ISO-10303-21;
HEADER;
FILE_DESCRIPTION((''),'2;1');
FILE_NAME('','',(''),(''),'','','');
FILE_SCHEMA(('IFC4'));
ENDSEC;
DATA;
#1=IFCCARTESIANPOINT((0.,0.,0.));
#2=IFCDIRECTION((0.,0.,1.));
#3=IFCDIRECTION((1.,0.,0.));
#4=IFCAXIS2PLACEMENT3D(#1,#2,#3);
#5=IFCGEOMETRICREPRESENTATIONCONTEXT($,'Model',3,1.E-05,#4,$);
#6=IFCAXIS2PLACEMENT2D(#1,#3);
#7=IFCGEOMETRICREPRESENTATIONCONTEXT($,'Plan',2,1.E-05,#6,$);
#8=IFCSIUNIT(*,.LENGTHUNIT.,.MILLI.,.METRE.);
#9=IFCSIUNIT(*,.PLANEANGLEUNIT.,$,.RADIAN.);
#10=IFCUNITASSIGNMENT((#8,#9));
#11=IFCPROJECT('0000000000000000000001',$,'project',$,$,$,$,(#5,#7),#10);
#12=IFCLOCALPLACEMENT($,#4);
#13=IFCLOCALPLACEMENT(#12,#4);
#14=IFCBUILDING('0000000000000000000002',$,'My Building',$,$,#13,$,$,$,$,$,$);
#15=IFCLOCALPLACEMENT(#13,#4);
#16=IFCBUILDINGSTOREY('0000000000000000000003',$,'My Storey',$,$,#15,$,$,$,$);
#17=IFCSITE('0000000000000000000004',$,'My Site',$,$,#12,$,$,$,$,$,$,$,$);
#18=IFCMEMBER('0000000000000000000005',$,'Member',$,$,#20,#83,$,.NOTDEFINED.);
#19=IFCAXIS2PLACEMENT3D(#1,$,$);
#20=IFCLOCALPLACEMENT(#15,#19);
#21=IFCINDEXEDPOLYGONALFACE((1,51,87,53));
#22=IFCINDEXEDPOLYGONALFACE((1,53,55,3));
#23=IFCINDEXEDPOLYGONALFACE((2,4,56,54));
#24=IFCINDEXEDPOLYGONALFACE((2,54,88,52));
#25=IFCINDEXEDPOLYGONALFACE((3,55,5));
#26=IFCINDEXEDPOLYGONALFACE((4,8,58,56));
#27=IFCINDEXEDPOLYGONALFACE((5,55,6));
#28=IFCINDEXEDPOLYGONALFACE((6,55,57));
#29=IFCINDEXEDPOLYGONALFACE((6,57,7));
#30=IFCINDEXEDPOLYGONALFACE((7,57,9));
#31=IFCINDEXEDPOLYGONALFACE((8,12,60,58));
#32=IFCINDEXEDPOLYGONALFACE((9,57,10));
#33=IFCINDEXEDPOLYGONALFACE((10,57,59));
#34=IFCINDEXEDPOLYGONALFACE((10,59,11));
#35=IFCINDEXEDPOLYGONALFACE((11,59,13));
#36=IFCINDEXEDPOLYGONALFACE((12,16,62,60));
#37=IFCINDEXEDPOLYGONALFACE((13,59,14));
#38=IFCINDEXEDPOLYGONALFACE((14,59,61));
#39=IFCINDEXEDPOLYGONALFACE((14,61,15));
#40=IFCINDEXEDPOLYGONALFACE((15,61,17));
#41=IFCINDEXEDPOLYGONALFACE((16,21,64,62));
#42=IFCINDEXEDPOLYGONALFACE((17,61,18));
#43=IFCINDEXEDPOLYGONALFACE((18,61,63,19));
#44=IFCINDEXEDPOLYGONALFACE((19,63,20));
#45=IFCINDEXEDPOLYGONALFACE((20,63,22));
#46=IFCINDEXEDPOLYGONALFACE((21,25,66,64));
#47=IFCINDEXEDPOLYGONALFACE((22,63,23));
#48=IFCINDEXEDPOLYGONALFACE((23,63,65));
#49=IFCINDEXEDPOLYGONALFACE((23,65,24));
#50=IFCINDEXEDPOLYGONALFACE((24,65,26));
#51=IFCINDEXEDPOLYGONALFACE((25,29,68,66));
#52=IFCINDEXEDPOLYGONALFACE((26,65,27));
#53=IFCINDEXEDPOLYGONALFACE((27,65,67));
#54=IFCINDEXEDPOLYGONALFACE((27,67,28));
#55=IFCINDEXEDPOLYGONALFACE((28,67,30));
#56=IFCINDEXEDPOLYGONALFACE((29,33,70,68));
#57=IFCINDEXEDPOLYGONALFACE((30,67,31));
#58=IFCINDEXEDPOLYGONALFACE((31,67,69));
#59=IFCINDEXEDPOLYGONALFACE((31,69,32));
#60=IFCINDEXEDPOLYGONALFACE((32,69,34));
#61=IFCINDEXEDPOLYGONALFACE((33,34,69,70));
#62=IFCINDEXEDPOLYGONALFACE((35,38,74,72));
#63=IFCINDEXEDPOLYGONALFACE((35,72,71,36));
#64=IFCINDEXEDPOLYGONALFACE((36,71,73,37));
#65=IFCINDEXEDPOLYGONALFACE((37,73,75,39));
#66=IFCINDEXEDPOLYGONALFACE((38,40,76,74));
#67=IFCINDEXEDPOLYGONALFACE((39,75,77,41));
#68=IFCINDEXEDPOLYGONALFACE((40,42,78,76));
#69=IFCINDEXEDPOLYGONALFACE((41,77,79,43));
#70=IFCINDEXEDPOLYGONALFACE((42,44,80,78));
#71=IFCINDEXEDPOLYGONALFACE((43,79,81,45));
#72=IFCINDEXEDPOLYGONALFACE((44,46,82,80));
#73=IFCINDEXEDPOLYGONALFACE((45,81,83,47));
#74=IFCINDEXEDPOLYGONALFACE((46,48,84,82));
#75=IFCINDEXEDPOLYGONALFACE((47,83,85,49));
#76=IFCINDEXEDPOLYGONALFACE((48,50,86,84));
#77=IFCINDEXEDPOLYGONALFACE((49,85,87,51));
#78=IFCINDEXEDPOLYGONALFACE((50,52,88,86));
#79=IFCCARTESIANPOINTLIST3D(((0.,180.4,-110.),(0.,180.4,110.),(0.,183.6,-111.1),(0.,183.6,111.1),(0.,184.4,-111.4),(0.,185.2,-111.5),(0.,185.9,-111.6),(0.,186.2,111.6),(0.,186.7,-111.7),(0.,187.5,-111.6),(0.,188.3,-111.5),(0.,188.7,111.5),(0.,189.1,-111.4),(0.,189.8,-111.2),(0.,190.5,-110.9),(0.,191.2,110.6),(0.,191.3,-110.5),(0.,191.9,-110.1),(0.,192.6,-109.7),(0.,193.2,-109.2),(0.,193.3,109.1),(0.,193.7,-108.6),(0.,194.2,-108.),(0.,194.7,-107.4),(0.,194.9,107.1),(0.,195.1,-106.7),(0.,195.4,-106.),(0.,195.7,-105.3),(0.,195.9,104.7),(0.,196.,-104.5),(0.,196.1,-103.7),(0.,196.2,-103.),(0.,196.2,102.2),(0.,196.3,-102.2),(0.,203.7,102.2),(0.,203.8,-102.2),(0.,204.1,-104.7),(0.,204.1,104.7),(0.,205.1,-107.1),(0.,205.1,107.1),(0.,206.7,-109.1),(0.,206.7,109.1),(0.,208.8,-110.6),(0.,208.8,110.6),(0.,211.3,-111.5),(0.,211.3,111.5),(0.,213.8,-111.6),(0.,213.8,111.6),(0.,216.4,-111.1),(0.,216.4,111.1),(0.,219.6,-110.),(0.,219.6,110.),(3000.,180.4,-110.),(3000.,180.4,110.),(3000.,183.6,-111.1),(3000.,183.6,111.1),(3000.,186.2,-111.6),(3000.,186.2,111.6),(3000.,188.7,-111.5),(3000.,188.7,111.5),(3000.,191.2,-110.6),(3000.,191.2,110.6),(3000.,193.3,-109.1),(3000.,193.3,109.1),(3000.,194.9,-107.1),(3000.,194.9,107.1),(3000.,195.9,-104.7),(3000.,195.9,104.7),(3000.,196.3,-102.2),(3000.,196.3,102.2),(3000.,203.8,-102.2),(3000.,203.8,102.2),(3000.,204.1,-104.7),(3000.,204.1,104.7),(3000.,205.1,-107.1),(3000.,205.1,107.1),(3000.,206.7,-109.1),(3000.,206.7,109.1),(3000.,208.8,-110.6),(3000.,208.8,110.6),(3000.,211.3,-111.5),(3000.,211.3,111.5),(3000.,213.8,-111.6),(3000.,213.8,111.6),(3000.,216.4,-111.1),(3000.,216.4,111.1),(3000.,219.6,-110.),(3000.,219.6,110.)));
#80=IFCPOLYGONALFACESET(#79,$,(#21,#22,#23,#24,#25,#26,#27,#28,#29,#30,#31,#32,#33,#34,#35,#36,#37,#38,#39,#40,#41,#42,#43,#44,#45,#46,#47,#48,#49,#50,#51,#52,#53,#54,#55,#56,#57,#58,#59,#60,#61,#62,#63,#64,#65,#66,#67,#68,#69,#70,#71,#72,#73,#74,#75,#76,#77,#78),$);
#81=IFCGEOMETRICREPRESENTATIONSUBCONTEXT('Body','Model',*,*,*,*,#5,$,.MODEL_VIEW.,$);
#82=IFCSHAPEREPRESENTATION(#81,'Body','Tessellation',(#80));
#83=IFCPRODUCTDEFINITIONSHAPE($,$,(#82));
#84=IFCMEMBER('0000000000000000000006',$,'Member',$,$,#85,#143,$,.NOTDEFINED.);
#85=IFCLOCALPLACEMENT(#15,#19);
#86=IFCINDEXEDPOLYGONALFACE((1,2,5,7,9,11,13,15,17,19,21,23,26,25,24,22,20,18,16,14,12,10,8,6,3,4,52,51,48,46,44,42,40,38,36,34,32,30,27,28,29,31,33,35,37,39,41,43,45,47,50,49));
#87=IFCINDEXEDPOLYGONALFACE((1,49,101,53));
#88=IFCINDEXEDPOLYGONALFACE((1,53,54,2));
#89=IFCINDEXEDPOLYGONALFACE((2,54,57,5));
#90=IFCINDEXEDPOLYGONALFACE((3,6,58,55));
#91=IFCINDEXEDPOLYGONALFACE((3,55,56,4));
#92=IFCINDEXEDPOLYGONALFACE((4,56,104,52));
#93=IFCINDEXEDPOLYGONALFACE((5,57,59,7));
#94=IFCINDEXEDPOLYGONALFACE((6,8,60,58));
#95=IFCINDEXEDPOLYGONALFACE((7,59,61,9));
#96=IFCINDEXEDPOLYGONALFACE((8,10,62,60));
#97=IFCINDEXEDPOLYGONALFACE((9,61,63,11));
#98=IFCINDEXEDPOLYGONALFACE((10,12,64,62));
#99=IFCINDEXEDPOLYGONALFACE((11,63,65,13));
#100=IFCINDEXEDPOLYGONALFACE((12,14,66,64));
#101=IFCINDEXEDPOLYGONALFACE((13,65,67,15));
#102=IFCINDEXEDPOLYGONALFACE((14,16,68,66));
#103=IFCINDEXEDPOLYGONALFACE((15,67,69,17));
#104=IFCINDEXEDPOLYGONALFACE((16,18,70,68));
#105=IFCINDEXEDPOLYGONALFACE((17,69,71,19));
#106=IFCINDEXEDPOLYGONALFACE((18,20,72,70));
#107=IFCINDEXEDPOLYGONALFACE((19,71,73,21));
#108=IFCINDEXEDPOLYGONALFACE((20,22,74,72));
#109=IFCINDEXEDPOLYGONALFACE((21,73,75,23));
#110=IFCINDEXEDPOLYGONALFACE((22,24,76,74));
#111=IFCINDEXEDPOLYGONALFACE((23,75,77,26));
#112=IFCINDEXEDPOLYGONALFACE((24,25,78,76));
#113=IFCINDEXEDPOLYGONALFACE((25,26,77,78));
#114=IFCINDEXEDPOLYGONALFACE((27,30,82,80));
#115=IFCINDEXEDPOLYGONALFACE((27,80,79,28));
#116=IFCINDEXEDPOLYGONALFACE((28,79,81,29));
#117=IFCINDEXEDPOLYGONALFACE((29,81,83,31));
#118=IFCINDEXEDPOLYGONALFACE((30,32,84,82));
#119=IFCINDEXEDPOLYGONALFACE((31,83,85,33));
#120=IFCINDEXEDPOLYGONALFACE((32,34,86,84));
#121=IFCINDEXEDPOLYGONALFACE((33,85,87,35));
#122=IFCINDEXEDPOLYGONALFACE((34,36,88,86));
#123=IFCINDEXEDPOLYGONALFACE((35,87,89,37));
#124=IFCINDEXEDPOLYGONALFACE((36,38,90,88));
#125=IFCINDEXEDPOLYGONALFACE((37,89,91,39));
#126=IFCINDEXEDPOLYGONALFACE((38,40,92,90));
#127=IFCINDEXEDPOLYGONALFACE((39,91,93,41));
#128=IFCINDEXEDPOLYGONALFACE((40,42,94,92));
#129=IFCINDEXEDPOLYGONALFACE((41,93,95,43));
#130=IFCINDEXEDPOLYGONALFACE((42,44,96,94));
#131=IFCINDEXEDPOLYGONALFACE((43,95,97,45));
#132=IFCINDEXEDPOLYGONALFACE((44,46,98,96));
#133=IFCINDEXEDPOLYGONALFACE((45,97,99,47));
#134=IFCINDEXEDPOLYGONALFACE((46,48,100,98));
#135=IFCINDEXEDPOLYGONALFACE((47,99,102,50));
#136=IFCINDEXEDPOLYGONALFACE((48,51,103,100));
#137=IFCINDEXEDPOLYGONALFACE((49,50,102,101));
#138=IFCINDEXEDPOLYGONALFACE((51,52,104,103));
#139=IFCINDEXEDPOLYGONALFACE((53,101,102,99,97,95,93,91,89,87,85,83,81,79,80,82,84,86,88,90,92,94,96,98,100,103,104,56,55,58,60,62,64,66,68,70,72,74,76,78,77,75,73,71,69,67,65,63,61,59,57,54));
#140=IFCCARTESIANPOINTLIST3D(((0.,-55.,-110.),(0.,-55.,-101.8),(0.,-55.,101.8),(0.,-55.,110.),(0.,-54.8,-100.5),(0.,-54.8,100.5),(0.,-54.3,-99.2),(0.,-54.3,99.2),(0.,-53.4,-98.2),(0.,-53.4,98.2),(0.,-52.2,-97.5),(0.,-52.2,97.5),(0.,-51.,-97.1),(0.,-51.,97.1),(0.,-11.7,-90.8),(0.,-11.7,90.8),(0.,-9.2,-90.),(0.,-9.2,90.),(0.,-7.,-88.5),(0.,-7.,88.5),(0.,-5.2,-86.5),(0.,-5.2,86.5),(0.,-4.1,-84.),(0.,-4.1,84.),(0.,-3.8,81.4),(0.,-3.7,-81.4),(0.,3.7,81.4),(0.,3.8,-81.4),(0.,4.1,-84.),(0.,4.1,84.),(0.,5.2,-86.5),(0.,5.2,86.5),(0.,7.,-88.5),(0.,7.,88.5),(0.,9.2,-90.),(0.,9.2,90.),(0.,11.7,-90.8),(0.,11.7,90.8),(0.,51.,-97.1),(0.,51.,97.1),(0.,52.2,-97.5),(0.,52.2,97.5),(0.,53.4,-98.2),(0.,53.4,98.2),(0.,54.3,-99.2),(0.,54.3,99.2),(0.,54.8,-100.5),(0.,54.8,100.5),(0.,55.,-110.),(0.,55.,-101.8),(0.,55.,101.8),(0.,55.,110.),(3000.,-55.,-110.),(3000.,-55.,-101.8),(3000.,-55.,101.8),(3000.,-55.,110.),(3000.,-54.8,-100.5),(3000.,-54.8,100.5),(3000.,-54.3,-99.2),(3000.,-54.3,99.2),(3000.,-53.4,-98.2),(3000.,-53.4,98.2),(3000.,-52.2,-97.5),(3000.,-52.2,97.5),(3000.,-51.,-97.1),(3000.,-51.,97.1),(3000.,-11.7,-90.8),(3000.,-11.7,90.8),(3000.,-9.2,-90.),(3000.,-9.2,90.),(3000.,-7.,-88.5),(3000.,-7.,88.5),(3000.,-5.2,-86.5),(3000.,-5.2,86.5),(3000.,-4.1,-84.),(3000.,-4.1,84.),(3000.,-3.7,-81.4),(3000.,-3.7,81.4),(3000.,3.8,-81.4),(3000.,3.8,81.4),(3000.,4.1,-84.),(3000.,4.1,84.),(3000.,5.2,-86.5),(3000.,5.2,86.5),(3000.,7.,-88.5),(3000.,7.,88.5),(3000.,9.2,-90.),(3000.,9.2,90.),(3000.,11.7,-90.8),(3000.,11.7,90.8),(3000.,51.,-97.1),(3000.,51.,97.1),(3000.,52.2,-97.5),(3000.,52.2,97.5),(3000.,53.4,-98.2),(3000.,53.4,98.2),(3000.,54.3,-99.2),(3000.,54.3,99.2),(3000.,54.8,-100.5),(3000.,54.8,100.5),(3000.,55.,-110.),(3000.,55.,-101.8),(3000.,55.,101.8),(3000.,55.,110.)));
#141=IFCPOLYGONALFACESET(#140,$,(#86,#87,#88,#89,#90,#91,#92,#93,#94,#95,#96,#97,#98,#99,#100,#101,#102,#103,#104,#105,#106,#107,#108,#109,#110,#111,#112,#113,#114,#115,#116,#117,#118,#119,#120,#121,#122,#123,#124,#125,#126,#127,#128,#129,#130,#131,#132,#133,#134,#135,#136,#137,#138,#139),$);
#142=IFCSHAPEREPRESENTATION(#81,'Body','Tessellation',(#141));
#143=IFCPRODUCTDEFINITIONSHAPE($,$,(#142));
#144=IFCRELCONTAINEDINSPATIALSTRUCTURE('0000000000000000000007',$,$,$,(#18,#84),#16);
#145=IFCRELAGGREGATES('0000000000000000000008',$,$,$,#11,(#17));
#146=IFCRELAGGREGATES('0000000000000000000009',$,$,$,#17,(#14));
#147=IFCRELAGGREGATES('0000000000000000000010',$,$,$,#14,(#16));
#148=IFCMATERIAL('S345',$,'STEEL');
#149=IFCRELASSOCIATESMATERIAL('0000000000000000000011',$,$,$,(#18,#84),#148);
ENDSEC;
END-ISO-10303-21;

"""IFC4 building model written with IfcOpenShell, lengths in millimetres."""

from ifc_helpers import new_model, si_unit, frame, frame_2d, origin_with_axes, place, context, subcontext, project, spatial, i_section, extrude, material, material_profile, profile_set, profile_usage, element, save


model = new_model("IFC4")

# Units and contexts
model_context = context("Model", 3, precision=1e-05, world=origin_with_axes())
plan_context = context("Plan", 2, precision=1e-05, world=frame_2d((0.0, 0.0, 0.0), x_axis=(1.0, 0.0, 0.0)))
body_context = subcontext(model_context, "Body", "Model", "MODEL_VIEW")
ifc_project = project(units=[si_unit("LENGTHUNIT", "METRE", prefix="MILLI"), si_unit("PLANEANGLEUNIT", "RADIAN")], contexts=[model_context, plan_context])

# Site, building, storey
site_placement = place(None, origin_with_axes())
site = spatial("IfcSite", under=ifc_project, at=site_placement, Name="My Site")
building_placement = place(site_placement, origin_with_axes())
building = spatial("IfcBuilding", under=site, at=building_placement, Name="My Building")
storey_placement = place(building_placement, origin_with_axes())
storey = spatial("IfcBuildingStorey", under=building, at=storey_placement, Name="My Storey")

# Members
ifc_material = material(Name="S345", Category="STEEL")
ifc_material_profile_1 = material_profile(ifc_material, i_section(OverallWidth=110.0, OverallDepth=220.0, WebThickness=7.5, FlangeThickness=12.3, FilletRadius=9.5, FlangeEdgeRadius=4.8, FlangeSlope=9.09))
ifc_profile_set_1 = profile_set([ifc_material_profile_1])
ifc_profile_usage_1 = profile_usage(ifc_profile_set_1)
member_1_placement = place(storey_placement, frame((0.0, 200.0, 0.0), z_axis=(1.0, 0.0, 0.0), x_axis=(0.0, 1.0, 0.0)))
element("IfcMember", 1, at=member_1_placement, inside=storey, material=ifc_profile_usage_1, Name="Member", PredefinedType="NOTDEFINED", context=body_context, shape_type="SweptSolid", body=[
    extrude(i_section(OverallWidth=110.0, OverallDepth=220.0, WebThickness=7.5, FlangeThickness=12.3, FilletRadius=9.5, FlangeEdgeRadius=4.8, FlangeSlope=9.09), origin_with_axes(), (0.0, 0.0, 1.0), 3000.0),
])
ifc_material_profile_2 = material_profile(ifc_material, i_section(OverallWidth=110.0, OverallDepth=220.0, WebThickness=7.5, FlangeThickness=12.3, FilletRadius=9.5, FlangeEdgeRadius=4.8, FlangeSlope=0.158655))
ifc_profile_set_2 = profile_set([ifc_material_profile_2])
ifc_profile_usage_2 = profile_usage(ifc_profile_set_2)
member_2_placement = place(storey_placement, frame((0.0, 0.0, 0.0), z_axis=(1.0, 0.0, 0.0), x_axis=(0.0, 1.0, 0.0)))
element("IfcMember", 2, at=member_2_placement, inside=storey, material=ifc_profile_usage_2, Name="Member", PredefinedType="NOTDEFINED", context=body_context, shape_type="SweptSolid", body=[
    extrude(i_section(OverallWidth=110.0, OverallDepth=220.0, WebThickness=7.5, FlangeThickness=12.3, FilletRadius=9.5, FlangeEdgeRadius=4.8, FlangeSlope=0.158655), origin_with_axes(), (0.0, 0.0, 1.0), 3000.0),
])

save(model, "model.ifc")
